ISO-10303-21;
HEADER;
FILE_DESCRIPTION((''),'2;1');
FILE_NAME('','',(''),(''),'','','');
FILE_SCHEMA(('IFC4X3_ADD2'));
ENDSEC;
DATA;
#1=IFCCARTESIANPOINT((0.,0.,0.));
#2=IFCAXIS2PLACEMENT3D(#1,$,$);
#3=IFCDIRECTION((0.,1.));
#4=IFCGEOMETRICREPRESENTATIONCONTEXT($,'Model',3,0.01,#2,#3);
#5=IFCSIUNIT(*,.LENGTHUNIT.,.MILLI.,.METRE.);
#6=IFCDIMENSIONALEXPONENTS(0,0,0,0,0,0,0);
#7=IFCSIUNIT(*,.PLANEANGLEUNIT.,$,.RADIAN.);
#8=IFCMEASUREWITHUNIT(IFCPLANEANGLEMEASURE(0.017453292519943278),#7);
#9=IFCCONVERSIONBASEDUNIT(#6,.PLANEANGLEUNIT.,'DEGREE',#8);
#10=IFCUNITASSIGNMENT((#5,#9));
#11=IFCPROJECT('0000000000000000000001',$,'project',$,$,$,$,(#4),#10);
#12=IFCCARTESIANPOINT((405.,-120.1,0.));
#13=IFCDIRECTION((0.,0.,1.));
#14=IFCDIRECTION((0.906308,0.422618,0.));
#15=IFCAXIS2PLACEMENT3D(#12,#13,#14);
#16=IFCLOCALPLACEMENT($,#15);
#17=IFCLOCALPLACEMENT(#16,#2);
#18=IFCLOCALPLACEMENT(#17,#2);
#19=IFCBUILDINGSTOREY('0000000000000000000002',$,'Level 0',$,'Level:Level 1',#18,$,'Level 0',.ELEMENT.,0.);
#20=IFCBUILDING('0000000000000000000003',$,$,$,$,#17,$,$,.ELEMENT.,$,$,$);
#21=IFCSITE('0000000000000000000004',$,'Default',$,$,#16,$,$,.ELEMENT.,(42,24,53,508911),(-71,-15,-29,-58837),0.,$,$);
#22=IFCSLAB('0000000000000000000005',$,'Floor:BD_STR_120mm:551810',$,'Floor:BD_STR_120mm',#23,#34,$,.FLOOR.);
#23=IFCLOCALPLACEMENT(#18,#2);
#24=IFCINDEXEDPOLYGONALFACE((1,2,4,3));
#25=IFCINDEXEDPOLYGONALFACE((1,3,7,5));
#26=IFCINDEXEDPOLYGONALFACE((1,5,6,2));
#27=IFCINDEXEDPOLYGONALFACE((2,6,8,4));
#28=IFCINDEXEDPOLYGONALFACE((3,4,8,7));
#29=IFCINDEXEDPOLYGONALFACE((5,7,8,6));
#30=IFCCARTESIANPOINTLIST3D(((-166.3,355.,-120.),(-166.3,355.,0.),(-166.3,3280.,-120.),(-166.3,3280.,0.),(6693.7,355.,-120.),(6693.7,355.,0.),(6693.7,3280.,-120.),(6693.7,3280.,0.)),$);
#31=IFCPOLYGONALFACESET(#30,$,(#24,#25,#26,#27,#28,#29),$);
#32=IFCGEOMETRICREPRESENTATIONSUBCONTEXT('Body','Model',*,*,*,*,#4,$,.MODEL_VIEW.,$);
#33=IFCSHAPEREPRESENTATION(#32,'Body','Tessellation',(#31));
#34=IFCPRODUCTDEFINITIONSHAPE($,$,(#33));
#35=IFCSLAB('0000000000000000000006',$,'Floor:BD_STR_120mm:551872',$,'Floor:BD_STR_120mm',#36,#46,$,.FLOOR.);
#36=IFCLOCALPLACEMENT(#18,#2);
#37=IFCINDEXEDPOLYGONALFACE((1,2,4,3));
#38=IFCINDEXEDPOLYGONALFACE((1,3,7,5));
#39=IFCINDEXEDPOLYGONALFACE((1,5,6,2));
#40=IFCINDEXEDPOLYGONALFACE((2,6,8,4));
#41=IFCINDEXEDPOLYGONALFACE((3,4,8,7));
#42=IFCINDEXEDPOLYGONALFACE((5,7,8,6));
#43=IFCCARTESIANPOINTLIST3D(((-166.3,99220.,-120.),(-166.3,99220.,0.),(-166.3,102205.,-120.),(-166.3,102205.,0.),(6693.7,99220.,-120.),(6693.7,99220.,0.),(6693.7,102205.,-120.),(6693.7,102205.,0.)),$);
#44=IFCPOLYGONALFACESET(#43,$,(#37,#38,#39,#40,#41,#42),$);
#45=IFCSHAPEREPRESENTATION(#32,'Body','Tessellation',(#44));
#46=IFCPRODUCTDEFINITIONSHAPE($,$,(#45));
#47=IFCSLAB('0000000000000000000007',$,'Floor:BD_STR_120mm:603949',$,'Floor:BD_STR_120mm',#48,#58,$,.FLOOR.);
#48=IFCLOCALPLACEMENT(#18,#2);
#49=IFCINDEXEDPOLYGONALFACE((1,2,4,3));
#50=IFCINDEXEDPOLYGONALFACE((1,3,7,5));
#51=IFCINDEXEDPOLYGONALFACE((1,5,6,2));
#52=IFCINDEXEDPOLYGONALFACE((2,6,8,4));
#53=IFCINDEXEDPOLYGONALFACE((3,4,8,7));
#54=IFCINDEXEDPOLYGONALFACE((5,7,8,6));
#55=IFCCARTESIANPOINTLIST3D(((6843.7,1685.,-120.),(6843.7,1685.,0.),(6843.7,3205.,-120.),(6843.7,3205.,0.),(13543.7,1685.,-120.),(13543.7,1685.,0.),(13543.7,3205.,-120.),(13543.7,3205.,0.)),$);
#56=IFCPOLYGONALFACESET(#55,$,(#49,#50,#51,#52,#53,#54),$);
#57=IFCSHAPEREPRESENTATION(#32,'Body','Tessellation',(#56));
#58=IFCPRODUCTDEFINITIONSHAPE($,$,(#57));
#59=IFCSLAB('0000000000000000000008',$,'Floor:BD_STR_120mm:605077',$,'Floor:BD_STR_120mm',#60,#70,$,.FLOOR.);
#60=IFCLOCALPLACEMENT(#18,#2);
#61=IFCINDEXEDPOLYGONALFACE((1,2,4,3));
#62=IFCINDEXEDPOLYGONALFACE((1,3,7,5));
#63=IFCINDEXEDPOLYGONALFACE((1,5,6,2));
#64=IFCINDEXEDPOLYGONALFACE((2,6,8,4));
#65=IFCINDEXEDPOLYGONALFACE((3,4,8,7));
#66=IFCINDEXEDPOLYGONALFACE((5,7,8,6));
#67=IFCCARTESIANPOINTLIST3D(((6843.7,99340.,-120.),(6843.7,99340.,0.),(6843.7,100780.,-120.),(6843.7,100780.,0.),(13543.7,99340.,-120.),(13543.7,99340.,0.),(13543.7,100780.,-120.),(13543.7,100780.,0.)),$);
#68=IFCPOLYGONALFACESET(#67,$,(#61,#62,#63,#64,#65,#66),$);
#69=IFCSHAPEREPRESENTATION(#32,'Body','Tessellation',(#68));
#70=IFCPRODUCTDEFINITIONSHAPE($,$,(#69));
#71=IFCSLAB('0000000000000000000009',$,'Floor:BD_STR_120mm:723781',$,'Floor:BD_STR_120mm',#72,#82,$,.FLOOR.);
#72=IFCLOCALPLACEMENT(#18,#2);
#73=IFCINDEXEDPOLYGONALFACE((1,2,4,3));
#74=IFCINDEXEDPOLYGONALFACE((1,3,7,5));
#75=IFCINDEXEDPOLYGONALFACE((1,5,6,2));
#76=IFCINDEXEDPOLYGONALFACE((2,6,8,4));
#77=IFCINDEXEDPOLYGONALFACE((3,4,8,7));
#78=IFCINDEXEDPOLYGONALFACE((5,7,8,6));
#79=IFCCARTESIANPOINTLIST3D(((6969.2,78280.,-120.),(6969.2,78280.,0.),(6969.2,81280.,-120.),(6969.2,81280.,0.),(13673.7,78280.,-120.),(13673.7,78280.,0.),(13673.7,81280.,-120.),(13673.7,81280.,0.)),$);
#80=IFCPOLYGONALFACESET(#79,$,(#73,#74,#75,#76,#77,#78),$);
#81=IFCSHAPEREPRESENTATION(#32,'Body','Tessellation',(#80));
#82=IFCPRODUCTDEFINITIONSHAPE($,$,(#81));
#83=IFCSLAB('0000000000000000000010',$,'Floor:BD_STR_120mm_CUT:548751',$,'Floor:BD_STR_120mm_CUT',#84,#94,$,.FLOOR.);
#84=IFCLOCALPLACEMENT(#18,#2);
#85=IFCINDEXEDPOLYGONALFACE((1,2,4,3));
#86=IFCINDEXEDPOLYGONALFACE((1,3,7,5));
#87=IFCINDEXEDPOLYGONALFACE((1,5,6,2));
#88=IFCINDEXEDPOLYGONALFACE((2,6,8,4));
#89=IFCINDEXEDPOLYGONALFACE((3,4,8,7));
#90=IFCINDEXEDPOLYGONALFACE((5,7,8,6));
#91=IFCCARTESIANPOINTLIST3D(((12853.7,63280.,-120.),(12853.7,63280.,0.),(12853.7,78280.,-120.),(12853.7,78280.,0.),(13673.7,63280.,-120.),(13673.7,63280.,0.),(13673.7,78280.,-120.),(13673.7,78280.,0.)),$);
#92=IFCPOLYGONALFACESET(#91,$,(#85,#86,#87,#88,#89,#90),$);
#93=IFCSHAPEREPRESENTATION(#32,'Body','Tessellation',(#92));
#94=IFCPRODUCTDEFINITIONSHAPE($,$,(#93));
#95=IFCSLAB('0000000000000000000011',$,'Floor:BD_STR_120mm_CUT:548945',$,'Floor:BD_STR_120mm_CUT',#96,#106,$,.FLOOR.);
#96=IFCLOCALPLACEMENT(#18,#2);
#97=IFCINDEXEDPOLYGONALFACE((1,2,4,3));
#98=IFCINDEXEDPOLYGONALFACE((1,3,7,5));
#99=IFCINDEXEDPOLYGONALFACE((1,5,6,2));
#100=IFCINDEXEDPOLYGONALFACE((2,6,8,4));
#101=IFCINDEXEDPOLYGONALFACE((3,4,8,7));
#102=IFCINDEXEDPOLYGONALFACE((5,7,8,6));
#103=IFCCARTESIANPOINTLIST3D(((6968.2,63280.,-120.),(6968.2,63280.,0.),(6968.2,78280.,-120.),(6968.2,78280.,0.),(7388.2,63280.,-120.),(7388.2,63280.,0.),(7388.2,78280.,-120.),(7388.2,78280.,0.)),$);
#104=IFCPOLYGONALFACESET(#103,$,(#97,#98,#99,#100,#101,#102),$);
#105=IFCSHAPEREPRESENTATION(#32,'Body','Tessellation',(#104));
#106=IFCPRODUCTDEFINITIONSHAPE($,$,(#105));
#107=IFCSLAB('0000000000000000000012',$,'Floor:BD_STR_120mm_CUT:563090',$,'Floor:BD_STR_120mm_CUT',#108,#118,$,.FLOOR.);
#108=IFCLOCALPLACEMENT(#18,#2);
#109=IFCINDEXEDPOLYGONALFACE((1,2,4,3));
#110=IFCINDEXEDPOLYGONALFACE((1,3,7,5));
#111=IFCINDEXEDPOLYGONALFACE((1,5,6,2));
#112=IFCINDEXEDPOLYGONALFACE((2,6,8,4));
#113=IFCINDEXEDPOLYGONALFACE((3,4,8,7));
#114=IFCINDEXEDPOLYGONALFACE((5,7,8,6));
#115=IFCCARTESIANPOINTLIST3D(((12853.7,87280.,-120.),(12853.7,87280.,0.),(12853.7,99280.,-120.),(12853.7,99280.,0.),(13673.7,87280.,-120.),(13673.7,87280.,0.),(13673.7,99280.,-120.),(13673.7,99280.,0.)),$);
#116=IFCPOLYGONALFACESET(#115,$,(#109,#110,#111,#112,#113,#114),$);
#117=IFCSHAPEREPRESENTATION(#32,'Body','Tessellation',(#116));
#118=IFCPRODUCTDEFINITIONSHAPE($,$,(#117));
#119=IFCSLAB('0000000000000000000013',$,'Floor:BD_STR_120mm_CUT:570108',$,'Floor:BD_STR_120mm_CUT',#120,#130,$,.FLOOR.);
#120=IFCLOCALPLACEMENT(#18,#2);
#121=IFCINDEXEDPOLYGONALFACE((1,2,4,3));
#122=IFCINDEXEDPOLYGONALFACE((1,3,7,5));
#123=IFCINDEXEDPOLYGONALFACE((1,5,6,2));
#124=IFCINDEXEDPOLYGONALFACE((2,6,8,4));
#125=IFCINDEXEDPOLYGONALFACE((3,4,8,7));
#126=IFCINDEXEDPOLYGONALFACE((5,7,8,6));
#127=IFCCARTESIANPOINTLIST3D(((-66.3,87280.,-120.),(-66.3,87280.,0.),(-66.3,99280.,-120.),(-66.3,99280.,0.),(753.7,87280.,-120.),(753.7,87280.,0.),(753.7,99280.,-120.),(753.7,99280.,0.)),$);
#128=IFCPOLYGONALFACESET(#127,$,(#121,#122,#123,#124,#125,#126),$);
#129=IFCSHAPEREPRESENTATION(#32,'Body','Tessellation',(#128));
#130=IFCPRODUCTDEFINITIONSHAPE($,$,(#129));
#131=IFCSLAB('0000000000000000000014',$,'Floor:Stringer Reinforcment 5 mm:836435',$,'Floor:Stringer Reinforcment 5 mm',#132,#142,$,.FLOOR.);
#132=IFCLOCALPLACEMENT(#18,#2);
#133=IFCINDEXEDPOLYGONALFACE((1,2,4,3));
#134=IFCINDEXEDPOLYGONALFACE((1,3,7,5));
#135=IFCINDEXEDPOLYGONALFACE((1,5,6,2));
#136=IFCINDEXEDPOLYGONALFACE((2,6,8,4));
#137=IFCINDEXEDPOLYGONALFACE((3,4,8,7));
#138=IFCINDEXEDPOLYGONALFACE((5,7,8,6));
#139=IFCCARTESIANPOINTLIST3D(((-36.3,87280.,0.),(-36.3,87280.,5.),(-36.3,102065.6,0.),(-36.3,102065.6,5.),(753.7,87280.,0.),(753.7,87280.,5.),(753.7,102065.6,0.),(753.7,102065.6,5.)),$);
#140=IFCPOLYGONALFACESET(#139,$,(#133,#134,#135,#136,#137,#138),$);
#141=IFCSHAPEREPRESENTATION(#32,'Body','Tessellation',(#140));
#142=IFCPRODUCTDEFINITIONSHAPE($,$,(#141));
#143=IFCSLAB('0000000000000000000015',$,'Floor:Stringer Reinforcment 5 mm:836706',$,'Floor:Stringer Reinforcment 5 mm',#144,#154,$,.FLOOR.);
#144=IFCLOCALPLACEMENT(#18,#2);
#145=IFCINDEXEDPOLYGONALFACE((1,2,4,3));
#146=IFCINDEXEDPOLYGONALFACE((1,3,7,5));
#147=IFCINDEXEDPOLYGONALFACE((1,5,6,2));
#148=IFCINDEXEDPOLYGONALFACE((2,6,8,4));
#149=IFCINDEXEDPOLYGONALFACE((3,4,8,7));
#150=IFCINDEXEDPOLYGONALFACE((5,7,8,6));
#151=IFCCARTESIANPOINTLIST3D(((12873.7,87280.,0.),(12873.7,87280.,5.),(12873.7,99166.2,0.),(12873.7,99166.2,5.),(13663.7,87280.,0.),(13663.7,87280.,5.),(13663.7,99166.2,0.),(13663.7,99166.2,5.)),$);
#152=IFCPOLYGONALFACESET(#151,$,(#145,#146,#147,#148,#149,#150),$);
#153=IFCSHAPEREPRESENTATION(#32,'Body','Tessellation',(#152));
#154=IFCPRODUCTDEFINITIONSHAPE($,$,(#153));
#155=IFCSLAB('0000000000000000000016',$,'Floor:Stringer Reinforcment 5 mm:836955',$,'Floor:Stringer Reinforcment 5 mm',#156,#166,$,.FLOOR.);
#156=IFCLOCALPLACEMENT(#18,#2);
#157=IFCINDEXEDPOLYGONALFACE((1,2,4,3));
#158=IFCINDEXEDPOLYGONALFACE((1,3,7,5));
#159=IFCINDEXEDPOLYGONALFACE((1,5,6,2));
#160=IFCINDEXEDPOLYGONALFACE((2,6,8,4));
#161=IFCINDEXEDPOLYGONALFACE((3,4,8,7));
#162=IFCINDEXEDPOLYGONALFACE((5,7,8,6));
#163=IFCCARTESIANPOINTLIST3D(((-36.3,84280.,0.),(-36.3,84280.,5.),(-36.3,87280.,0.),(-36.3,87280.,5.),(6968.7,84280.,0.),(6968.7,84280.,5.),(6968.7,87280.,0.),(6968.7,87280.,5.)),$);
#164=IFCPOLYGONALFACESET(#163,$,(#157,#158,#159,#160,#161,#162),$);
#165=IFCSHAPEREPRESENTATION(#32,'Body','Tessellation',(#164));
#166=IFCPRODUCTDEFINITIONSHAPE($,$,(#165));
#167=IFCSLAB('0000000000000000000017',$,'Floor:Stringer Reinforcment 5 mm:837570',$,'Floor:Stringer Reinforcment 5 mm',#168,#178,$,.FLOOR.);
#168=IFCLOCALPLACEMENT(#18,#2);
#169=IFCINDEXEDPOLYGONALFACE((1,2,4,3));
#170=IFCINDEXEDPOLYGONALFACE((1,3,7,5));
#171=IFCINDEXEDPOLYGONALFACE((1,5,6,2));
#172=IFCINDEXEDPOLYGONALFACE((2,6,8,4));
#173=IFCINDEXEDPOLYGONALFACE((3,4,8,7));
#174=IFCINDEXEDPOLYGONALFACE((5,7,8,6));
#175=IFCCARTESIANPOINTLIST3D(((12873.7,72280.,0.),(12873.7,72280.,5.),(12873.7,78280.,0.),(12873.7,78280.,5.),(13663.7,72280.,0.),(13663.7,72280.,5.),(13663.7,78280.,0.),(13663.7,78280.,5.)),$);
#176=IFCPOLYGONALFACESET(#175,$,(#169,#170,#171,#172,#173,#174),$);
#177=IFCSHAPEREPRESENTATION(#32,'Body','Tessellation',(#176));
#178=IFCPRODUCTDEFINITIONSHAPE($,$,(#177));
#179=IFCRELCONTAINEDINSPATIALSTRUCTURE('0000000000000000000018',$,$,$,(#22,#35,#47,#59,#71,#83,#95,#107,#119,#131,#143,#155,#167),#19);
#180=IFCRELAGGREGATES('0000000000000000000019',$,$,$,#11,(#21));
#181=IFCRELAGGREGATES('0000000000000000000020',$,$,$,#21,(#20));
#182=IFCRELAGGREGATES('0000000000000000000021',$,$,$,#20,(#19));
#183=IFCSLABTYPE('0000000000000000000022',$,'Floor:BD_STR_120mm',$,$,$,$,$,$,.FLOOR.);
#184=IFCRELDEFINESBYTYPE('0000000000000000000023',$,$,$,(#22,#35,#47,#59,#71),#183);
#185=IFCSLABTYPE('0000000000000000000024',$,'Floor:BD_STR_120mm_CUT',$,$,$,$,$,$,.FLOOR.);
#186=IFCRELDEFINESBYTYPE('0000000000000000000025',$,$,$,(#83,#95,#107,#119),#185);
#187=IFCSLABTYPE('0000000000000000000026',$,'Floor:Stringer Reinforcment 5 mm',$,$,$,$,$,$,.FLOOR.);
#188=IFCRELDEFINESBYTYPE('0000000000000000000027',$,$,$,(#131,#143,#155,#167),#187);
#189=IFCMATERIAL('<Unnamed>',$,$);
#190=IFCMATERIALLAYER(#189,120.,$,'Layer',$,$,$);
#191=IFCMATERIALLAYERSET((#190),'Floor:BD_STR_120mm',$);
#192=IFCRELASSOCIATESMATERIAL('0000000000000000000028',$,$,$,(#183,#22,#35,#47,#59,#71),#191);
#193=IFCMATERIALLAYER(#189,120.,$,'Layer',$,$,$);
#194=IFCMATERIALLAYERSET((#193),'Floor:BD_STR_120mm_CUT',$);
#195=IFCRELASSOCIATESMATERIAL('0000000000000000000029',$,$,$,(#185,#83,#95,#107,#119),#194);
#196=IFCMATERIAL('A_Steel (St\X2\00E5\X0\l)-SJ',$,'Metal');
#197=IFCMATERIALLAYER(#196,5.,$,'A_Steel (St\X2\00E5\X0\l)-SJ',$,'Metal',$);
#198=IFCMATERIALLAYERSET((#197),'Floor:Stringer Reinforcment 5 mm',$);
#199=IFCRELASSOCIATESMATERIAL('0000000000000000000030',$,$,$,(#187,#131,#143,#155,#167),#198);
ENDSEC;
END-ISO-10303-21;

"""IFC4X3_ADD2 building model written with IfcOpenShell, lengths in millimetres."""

from ifc_helpers import new_model, entity, si_unit, converted_unit, direction, frame, frame_2d, origin, origin_2d_with_axis, place, context, subcontext, project, spatial, rectangle, extrude, material, layer, layer_set, layer_usage, type_object, element, save


model = new_model("IFC4X3_ADD2")

# Units and contexts
model_context = context("Model", 3, precision=0.01, world=origin(), true_north=direction((0.0, 1.0)))
body_context = subcontext(model_context, "Body", "Model", "MODEL_VIEW")
ifc_project = project(units=[si_unit("LENGTHUNIT", "METRE", prefix="MILLI"), converted_unit("PLANEANGLEUNIT", "DEGREE", entity("IfcPlaneAngleMeasure", 0.017453292519943278), si_unit("PLANEANGLEUNIT", "RADIAN"), dimensions=[0, 0, 0, 0, 0, 0, 0])], contexts=[model_context])

# Site, building, storey
site_placement = place(None, frame((405.0, -120.1, 0.0), z_axis=(0.0, 0.0, 1.0), x_axis=(0.906308, 0.422618, 0.0)))
site = spatial("IfcSite", under=ifc_project, at=site_placement, Name="Default", CompositionType="ELEMENT", RefLatitude=(42, 24, 53, 508911), RefLongitude=(-71, -15, -29, -58837), RefElevation=0.0)
building_placement = place(site_placement, origin())
building = spatial("IfcBuilding", under=site, at=building_placement, CompositionType="ELEMENT")
storey_placement = place(building_placement, origin())
storey = spatial("IfcBuildingStorey", under=building, at=storey_placement, Name="Level 0", ObjectType="Level:Level 1", LongName="Level 0", CompositionType="ELEMENT", Elevation=0.0)

# Slabs
ifc_material_1 = material(Name="<Unnamed>")
ifc_layer_1 = layer(ifc_material_1, 120.0, Name="Layer")
ifc_layer_set_1 = layer_set([ifc_layer_1], Name="Floor:BD_STR_120mm")
slab_type_1 = type_object("IfcSlabType", Name="Floor:BD_STR_120mm", PredefinedType="FLOOR", material=ifc_layer_set_1)
ifc_layer_usage_1 = layer_usage(ifc_layer_set_1, "AXIS3", "POSITIVE", 0.0)
slab_1_placement = place(storey_placement, origin())
element("IfcSlab", 1, at=slab_1_placement, inside=storey, type_object=slab_type_1, material=ifc_layer_usage_1, Name="Floor:BD_STR_120mm:551810", ObjectType="Floor:BD_STR_120mm", PredefinedType="FLOOR", context=body_context, shape_type="SweptSolid", body=[
    extrude(rectangle(XDim=2925.0, YDim=6860.0, at=origin_2d_with_axis()), frame((3263.7, 1817.5, 0.0), z_axis=(0.0, 0.0, -1.0), x_axis=(0.0, 1.0, 0.0)), (0.0, 0.0, 1.0), 120.0),
])
ifc_layer_usage_2 = layer_usage(ifc_layer_set_1, "AXIS3", "POSITIVE", 0.0)
slab_2_placement = place(storey_placement, origin())
element("IfcSlab", 2, at=slab_2_placement, inside=storey, type_object=slab_type_1, material=ifc_layer_usage_2, Name="Floor:BD_STR_120mm:551872", ObjectType="Floor:BD_STR_120mm", PredefinedType="FLOOR", context=body_context, shape_type="SweptSolid", body=[
    extrude(rectangle(XDim=2985.0, YDim=6860.0, at=frame_2d((0.0, 0.0), x_axis=(1.0, 0.0))), frame((3263.7, 100712.5, 0.0), z_axis=(0.0, 0.0, -1.0), x_axis=(0.0, 1.0, 0.0)), (0.0, 0.0, 1.0), 120.0),
])
ifc_layer_usage_3 = layer_usage(ifc_layer_set_1, "AXIS3", "POSITIVE", 0.0)
slab_3_placement = place(storey_placement, origin())
element("IfcSlab", 3, at=slab_3_placement, inside=storey, type_object=slab_type_1, material=ifc_layer_usage_3, Name="Floor:BD_STR_120mm:603949", ObjectType="Floor:BD_STR_120mm", PredefinedType="FLOOR", context=body_context, shape_type="SweptSolid", body=[
    extrude(rectangle(XDim=1520.0, YDim=6700.0, at=frame_2d((0.0, 0.0), x_axis=(1.0, 0.0))), frame((10193.7, 2445.0, 0.0), z_axis=(0.0, 0.0, -1.0), x_axis=(0.0, 1.0, 0.0)), (0.0, 0.0, 1.0), 120.0),
])
ifc_layer_usage_4 = layer_usage(ifc_layer_set_1, "AXIS3", "POSITIVE", 0.0)
slab_4_placement = place(storey_placement, origin())
element("IfcSlab", 4, at=slab_4_placement, inside=storey, type_object=slab_type_1, material=ifc_layer_usage_4, Name="Floor:BD_STR_120mm:605077", ObjectType="Floor:BD_STR_120mm", PredefinedType="FLOOR", context=body_context, shape_type="SweptSolid", body=[
    extrude(rectangle(XDim=1440.0, YDim=6700.0, at=frame_2d((0.0, 0.0), x_axis=(1.0, 0.0))), frame((10193.7, 100060.0, 0.0), z_axis=(0.0, 0.0, -1.0), x_axis=(0.0, 1.0, 0.0)), (0.0, 0.0, 1.0), 120.0),
])
ifc_layer_usage_5 = layer_usage(ifc_layer_set_1, "AXIS3", "POSITIVE", 0.0)
slab_5_placement = place(storey_placement, origin())
element("IfcSlab", 5, at=slab_5_placement, inside=storey, type_object=slab_type_1, material=ifc_layer_usage_5, Name="Floor:BD_STR_120mm:723781", ObjectType="Floor:BD_STR_120mm", PredefinedType="FLOOR", context=body_context, shape_type="SweptSolid", body=[
    extrude(rectangle(XDim=3000.0, YDim=6704.5, at=frame_2d((0.0, 0.0), x_axis=(1.0, 0.0))), frame((10321.5, 79780.0, 0.0), z_axis=(0.0, 0.0, -1.0), x_axis=(0.0, 1.0, 0.0)), (0.0, 0.0, 1.0), 120.0),
])
ifc_layer_2 = layer(ifc_material_1, 120.0, Name="Layer")
ifc_layer_set_2 = layer_set([ifc_layer_2], Name="Floor:BD_STR_120mm_CUT")
ifc_layer_usage_6 = layer_usage(ifc_layer_set_2, "AXIS3", "POSITIVE", 0.0)
slab_type_2 = type_object("IfcSlabType", Name="Floor:BD_STR_120mm_CUT", PredefinedType="FLOOR", material=ifc_layer_set_2)
slab_6_placement = place(storey_placement, origin())
element("IfcSlab", 6, at=slab_6_placement, inside=storey, type_object=slab_type_2, material=ifc_layer_usage_6, Name="Floor:BD_STR_120mm_CUT:548751", ObjectType="Floor:BD_STR_120mm_CUT", PredefinedType="FLOOR", context=body_context, shape_type="SweptSolid", body=[
    extrude(rectangle(XDim=15000.0, YDim=820.0, at=frame_2d((0.0, 0.0), x_axis=(1.0, 0.0))), frame((13263.7, 70780.0, 0.0), z_axis=(0.0, 0.0, -1.0), x_axis=(0.0, 1.0, 0.0)), (0.0, 0.0, 1.0), 120.0),
])
ifc_layer_usage_7 = layer_usage(ifc_layer_set_2, "AXIS3", "POSITIVE", 0.0)
slab_7_placement = place(storey_placement, origin())
element("IfcSlab", 7, at=slab_7_placement, inside=storey, type_object=slab_type_2, material=ifc_layer_usage_7, Name="Floor:BD_STR_120mm_CUT:548945", ObjectType="Floor:BD_STR_120mm_CUT", PredefinedType="FLOOR", context=body_context, shape_type="SweptSolid", body=[
    extrude(rectangle(XDim=15000.0, YDim=420.0, at=frame_2d((0.0, 0.0), x_axis=(1.0, 0.0))), frame((7178.2, 70780.0, 0.0), z_axis=(0.0, 0.0, -1.0), x_axis=(0.0, 1.0, 0.0)), (0.0, 0.0, 1.0), 120.0),
])
ifc_layer_usage_8 = layer_usage(ifc_layer_set_2, "AXIS3", "POSITIVE", 0.0)
slab_8_placement = place(storey_placement, origin())
element("IfcSlab", 8, at=slab_8_placement, inside=storey, type_object=slab_type_2, material=ifc_layer_usage_8, Name="Floor:BD_STR_120mm_CUT:563090", ObjectType="Floor:BD_STR_120mm_CUT", PredefinedType="FLOOR", context=body_context, shape_type="SweptSolid", body=[
    extrude(rectangle(XDim=12000.0, YDim=820.0, at=frame_2d((0.0, 0.0), x_axis=(1.0, 0.0))), frame((13263.7, 93280.0, 0.0), z_axis=(0.0, 0.0, -1.0), x_axis=(0.0, 1.0, 0.0)), (0.0, 0.0, 1.0), 120.0),
])
ifc_layer_usage_9 = layer_usage(ifc_layer_set_2, "AXIS3", "POSITIVE", 0.0)
slab_9_placement = place(storey_placement, origin())
element("IfcSlab", 9, at=slab_9_placement, inside=storey, type_object=slab_type_2, material=ifc_layer_usage_9, Name="Floor:BD_STR_120mm_CUT:570108", ObjectType="Floor:BD_STR_120mm_CUT", PredefinedType="FLOOR", context=body_context, shape_type="SweptSolid", body=[
    extrude(rectangle(XDim=12000.0, YDim=820.0, at=frame_2d((0.0, 0.0), x_axis=(1.0, 0.0))), frame((343.7, 93280.0, 0.0), z_axis=(0.0, 0.0, -1.0), x_axis=(0.0, 1.0, 0.0)), (0.0, 0.0, 1.0), 120.0),
])
ifc_material_2 = material(Name="A_Steel (Stål)-SJ", Category="Metal")
ifc_layer_3 = layer(ifc_material_2, 5.0, Name="A_Steel (Stål)-SJ", Category="Metal")
ifc_layer_set_3 = layer_set([ifc_layer_3], Name="Floor:Stringer Reinforcment 5 mm")
ifc_layer_usage_10 = layer_usage(ifc_layer_set_3, "AXIS3", "POSITIVE", 0.0)
slab_type_3 = type_object("IfcSlabType", Name="Floor:Stringer Reinforcment 5 mm", PredefinedType="FLOOR", material=ifc_layer_set_3)
slab_10_placement = place(storey_placement, origin())
element("IfcSlab", 10, at=slab_10_placement, inside=storey, type_object=slab_type_3, material=ifc_layer_usage_10, Name="Floor:Stringer Reinforcment 5 mm:836435", ObjectType="Floor:Stringer Reinforcment 5 mm", PredefinedType="FLOOR", context=body_context, shape_type="SweptSolid", body=[
    extrude(rectangle(XDim=14785.6, YDim=790.0, at=origin_2d_with_axis()), frame((358.7, 94672.8, 5.0), z_axis=(0.0, 0.0, -1.0), x_axis=(0.0, 1.0, 0.0)), (0.0, 0.0, 1.0), 5.0),
])
ifc_layer_usage_11 = layer_usage(ifc_layer_set_3, "AXIS3", "POSITIVE", 0.0)
slab_11_placement = place(storey_placement, origin())
element("IfcSlab", 11, at=slab_11_placement, inside=storey, type_object=slab_type_3, material=ifc_layer_usage_11, Name="Floor:Stringer Reinforcment 5 mm:836706", ObjectType="Floor:Stringer Reinforcment 5 mm", PredefinedType="FLOOR", context=body_context, shape_type="SweptSolid", body=[
    extrude(rectangle(XDim=11886.2, YDim=790.0, at=frame_2d((0.0, 0.0), x_axis=(1.0, 0.0))), frame((13268.7, 93223.1, 5.0), z_axis=(0.0, 0.0, -1.0), x_axis=(0.0, 1.0, 0.0)), (0.0, 0.0, 1.0), 5.0),
])
ifc_layer_usage_12 = layer_usage(ifc_layer_set_3, "AXIS3", "POSITIVE", 0.0)
slab_12_placement = place(storey_placement, origin())
element("IfcSlab", 12, at=slab_12_placement, inside=storey, type_object=slab_type_3, material=ifc_layer_usage_12, Name="Floor:Stringer Reinforcment 5 mm:836955", ObjectType="Floor:Stringer Reinforcment 5 mm", PredefinedType="FLOOR", context=body_context, shape_type="SweptSolid", body=[
    extrude(rectangle(XDim=3000.0, YDim=7005.0, at=frame_2d((0.0, 0.0), x_axis=(1.0, 0.0))), frame((3466.2, 85780.0, 5.0), z_axis=(0.0, 0.0, -1.0), x_axis=(0.0, 1.0, 0.0)), (0.0, 0.0, 1.0), 5.0),
])
ifc_layer_usage_13 = layer_usage(ifc_layer_set_3, "AXIS3", "POSITIVE", 0.0)
slab_13_placement = place(storey_placement, origin())
element("IfcSlab", 13, at=slab_13_placement, inside=storey, type_object=slab_type_3, material=ifc_layer_usage_13, Name="Floor:Stringer Reinforcment 5 mm:837570", ObjectType="Floor:Stringer Reinforcment 5 mm", PredefinedType="FLOOR", context=body_context, shape_type="SweptSolid", body=[
    extrude(rectangle(XDim=6000.0, YDim=790.0, at=frame_2d((0.0, 0.0), x_axis=(1.0, 0.0))), frame((13268.7, 75280.0, 5.0), z_axis=(0.0, 0.0, -1.0), x_axis=(0.0, 1.0, 0.0)), (0.0, 0.0, 1.0), 5.0),
])

save(model, "model.ifc")
